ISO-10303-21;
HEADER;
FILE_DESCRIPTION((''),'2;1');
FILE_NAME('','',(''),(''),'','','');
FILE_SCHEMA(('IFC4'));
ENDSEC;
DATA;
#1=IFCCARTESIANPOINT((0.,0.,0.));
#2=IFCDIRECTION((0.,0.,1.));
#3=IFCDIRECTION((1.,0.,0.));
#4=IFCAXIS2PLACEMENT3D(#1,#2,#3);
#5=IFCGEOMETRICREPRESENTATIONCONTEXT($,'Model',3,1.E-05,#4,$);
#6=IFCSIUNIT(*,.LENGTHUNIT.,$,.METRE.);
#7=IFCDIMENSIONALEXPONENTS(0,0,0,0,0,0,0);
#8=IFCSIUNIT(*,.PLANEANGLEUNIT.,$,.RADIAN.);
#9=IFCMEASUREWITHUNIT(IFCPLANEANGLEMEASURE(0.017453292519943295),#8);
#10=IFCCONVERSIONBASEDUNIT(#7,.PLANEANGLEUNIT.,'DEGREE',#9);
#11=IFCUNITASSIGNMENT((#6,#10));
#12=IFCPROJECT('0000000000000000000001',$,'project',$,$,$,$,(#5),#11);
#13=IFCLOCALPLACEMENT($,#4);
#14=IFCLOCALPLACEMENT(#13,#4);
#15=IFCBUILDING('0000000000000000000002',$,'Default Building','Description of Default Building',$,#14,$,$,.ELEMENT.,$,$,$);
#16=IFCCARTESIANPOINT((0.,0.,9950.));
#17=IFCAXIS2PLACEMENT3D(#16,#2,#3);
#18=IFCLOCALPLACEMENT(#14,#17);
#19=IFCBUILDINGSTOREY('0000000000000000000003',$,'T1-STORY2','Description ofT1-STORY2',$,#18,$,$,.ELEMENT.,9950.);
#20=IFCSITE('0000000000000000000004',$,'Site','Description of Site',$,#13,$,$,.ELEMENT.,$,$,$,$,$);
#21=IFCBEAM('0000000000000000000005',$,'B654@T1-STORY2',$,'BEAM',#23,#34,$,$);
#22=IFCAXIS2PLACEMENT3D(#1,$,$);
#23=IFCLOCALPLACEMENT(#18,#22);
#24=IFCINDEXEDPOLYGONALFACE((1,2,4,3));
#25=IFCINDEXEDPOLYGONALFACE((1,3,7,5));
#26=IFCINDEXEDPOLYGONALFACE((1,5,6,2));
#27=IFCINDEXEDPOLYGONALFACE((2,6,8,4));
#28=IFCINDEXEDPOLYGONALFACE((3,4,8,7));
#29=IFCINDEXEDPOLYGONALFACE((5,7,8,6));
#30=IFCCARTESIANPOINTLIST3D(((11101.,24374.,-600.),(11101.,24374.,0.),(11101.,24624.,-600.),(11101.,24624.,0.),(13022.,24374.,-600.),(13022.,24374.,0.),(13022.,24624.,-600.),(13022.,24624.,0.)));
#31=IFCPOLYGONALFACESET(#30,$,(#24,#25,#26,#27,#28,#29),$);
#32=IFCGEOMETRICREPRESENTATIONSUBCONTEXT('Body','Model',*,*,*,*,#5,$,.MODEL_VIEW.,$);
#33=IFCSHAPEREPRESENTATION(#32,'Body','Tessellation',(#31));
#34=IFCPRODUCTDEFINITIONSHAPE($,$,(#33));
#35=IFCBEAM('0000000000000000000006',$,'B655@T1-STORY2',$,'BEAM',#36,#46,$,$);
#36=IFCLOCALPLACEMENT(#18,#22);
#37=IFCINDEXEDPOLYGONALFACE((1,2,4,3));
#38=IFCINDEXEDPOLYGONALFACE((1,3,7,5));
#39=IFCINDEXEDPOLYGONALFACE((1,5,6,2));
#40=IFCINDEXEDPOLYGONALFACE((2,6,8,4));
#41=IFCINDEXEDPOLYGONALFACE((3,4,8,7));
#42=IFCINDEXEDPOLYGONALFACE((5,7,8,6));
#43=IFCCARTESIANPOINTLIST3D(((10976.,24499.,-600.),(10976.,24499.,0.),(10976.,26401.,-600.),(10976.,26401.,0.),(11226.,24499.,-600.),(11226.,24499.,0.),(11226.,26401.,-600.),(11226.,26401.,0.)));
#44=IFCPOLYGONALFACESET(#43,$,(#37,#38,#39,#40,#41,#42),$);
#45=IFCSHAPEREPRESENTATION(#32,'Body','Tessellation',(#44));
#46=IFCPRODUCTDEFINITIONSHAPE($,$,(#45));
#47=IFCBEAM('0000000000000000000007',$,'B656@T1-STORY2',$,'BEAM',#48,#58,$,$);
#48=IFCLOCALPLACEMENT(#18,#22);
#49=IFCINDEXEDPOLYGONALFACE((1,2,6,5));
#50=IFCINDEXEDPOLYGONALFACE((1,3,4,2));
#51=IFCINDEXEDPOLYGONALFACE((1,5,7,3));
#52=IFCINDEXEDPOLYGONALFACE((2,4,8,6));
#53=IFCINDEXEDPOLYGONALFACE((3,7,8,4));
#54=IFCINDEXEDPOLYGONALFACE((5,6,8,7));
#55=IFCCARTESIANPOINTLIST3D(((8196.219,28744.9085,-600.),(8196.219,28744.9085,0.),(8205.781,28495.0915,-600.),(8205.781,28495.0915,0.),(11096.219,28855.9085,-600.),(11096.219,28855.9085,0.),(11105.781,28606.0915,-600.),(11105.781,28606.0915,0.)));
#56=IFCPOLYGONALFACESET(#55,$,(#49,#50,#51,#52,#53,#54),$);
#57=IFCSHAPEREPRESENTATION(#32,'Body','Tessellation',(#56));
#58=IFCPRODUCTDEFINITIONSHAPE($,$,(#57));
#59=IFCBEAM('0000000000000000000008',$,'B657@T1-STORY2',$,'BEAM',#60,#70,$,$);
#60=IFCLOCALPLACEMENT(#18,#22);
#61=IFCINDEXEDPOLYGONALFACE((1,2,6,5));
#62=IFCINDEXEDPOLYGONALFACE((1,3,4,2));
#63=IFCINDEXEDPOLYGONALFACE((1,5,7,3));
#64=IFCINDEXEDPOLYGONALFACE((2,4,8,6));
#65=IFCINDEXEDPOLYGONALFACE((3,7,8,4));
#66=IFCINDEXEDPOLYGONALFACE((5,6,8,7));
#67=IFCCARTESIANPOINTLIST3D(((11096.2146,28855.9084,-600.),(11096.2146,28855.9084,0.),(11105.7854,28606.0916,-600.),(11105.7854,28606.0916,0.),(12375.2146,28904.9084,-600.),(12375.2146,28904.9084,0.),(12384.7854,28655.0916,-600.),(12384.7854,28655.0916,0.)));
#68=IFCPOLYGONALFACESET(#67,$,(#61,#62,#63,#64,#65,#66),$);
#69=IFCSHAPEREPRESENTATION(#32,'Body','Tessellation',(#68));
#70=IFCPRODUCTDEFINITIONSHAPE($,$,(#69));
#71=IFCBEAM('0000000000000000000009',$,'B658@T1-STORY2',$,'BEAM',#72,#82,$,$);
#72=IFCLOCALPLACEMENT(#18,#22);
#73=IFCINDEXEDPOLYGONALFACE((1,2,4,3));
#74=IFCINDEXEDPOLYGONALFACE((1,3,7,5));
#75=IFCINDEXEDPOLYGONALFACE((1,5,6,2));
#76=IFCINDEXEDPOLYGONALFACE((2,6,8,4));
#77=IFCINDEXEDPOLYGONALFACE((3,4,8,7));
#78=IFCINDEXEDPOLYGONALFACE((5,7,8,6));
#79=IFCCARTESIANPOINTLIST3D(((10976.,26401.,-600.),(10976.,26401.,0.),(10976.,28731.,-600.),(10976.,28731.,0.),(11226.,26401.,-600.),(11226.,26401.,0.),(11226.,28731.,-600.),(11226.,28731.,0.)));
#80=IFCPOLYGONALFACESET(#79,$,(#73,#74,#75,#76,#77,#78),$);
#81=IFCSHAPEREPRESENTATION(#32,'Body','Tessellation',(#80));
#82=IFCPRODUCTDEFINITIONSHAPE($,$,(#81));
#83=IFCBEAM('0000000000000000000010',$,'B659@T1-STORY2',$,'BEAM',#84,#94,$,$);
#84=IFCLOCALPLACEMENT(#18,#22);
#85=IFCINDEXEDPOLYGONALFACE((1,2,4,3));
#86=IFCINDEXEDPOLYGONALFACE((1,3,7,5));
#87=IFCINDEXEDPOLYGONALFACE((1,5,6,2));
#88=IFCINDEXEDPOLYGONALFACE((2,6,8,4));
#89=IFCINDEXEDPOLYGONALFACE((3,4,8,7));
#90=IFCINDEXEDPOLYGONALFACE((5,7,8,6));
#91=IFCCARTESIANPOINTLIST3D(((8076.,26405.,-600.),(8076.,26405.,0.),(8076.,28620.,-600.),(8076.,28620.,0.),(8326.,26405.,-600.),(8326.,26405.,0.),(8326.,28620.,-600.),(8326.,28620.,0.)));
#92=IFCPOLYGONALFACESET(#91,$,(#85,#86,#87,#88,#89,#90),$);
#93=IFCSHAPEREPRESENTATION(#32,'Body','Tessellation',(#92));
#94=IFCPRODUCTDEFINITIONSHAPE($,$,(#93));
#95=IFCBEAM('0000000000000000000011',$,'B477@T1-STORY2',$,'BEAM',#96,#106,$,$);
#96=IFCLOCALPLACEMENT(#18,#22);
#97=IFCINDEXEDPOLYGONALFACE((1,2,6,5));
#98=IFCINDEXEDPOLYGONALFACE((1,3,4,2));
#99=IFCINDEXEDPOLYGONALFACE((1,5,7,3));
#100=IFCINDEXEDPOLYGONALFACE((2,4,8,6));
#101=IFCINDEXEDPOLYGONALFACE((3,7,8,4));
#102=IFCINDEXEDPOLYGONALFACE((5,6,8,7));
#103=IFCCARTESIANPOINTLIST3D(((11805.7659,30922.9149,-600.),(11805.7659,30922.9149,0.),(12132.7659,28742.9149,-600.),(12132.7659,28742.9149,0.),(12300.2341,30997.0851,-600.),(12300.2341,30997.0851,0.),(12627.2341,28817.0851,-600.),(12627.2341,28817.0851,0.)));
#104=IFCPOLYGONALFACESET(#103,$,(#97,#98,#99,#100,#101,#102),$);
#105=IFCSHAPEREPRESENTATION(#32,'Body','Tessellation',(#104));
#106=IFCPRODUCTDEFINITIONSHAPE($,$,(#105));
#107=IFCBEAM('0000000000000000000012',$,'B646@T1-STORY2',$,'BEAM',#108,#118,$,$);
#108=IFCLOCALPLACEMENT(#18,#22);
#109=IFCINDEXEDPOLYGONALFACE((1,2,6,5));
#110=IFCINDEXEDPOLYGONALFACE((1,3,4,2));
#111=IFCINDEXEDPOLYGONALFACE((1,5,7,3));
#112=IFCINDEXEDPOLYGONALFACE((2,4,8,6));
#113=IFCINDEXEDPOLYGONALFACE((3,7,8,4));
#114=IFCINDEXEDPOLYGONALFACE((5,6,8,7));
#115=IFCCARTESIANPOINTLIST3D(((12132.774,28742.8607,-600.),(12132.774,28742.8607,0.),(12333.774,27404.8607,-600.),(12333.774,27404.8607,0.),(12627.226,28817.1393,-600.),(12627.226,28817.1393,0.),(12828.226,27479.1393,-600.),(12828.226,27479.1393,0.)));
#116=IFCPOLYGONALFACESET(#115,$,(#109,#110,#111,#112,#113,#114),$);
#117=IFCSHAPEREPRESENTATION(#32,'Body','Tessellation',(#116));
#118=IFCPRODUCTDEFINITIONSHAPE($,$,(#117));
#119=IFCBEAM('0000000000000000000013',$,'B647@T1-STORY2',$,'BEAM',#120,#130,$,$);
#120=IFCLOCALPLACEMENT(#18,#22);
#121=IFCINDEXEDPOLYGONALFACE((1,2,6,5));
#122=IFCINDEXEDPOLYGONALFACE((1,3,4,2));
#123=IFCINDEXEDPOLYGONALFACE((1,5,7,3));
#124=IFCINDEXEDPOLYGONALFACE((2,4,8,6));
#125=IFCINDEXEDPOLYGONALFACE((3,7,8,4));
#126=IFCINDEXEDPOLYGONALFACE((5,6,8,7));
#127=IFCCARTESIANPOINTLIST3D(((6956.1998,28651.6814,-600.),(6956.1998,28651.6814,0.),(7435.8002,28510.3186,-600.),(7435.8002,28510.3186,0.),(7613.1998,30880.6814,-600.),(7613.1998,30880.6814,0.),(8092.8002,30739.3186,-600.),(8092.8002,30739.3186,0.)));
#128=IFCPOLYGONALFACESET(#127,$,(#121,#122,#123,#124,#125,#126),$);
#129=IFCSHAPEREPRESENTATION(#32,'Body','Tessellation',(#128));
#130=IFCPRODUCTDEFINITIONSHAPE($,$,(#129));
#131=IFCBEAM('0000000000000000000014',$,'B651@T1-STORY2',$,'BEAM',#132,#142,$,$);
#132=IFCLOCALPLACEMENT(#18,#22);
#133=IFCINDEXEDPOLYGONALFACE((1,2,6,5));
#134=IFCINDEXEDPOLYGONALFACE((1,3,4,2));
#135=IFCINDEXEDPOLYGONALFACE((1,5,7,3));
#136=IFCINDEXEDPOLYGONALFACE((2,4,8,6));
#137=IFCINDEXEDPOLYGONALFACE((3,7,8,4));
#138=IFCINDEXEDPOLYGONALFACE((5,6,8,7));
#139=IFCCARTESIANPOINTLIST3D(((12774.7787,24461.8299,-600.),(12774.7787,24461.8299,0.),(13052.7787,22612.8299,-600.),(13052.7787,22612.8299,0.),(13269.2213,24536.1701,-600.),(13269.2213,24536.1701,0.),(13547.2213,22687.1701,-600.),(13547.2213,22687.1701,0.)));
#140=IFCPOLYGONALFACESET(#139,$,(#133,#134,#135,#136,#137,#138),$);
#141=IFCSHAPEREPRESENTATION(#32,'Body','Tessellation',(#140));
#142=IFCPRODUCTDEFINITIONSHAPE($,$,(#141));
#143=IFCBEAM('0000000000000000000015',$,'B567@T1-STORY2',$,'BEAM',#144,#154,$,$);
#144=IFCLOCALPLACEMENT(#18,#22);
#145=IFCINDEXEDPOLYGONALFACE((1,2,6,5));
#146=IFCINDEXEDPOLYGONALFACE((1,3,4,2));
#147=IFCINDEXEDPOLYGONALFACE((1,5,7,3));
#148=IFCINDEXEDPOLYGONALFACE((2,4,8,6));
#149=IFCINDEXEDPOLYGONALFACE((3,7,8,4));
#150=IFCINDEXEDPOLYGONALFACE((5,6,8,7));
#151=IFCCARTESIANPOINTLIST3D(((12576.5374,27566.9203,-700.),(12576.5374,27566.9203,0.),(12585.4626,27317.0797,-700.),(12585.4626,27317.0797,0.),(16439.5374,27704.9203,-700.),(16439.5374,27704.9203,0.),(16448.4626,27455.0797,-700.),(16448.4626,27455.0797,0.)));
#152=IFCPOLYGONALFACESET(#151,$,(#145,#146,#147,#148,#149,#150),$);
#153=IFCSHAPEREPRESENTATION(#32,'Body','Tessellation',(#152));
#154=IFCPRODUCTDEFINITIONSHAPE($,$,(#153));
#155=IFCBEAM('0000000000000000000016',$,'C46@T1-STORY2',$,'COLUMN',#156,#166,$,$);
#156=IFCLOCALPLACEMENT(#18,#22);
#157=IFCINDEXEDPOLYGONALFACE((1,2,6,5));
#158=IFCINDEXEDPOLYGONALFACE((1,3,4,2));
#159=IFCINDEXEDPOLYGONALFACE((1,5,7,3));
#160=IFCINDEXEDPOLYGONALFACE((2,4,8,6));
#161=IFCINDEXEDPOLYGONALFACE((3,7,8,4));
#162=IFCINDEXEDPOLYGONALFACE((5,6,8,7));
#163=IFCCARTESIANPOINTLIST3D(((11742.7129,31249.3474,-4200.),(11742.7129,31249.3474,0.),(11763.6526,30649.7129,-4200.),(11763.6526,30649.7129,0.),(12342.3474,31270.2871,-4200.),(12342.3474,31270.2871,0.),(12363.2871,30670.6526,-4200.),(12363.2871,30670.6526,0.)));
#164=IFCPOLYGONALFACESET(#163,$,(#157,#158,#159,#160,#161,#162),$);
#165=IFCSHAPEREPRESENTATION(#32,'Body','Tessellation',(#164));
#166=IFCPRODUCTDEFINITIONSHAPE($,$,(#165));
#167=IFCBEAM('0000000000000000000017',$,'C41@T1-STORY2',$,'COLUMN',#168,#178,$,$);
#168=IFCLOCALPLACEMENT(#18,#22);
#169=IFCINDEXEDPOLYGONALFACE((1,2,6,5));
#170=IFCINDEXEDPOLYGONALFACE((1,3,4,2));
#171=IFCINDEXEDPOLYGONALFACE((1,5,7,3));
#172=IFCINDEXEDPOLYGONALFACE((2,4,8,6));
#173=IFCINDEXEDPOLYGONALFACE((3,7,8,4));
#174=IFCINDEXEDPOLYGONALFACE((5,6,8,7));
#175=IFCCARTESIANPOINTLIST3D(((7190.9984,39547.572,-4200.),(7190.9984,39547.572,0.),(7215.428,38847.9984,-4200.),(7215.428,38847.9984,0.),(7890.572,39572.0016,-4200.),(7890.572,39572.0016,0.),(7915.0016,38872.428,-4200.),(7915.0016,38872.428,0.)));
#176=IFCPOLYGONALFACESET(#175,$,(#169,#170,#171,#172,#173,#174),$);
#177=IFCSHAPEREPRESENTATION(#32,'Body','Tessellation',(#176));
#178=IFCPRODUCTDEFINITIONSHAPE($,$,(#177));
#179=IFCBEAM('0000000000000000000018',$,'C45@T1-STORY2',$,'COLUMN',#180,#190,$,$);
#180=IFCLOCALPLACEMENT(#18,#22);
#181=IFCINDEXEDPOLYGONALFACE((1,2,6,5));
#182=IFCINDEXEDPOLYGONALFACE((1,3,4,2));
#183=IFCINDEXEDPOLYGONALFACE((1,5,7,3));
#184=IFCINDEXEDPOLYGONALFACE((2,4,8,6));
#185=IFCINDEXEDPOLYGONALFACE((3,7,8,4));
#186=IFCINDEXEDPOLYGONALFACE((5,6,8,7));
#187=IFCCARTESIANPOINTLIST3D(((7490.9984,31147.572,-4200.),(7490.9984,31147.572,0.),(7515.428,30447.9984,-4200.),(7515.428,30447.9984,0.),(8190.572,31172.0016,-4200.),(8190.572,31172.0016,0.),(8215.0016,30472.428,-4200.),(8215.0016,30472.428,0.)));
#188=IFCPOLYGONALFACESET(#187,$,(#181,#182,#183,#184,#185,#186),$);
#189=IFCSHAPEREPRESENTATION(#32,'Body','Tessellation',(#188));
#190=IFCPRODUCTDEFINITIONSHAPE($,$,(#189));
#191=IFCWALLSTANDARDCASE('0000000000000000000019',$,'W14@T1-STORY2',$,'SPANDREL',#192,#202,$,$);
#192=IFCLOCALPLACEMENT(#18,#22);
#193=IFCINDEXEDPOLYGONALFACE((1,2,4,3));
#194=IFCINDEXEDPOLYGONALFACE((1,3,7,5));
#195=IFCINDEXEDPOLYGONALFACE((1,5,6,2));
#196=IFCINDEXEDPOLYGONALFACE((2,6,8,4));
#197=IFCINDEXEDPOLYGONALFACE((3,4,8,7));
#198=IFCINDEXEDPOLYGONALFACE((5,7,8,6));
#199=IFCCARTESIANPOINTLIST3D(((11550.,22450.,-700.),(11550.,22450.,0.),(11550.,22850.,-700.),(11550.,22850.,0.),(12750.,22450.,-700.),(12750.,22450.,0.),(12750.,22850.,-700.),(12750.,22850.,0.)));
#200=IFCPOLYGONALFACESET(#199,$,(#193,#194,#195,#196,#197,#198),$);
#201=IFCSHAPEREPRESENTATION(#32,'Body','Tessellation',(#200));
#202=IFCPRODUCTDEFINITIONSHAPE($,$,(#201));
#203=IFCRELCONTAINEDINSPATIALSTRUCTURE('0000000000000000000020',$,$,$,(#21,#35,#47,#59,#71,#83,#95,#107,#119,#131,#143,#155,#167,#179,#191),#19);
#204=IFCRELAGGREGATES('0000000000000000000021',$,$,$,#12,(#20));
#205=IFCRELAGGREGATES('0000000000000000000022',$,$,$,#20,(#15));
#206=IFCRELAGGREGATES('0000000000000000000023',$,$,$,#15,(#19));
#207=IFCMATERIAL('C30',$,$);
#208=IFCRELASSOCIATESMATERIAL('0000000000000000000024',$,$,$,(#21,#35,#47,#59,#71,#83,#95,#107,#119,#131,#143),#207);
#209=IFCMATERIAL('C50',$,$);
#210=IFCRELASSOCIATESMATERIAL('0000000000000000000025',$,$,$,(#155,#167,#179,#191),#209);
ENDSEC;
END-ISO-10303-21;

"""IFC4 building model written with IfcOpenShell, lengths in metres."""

from ifc_helpers import new_model, entity, si_unit, converted_unit, frame, origin_with_axes, place, context, subcontext, project, spatial, indexed_curve, rectangle, outline, extrude, material, element, save


model = new_model("IFC4")

# Units and contexts
model_context = context("Model", 3, precision=1e-05, world=origin_with_axes())
body_context = subcontext(model_context, "Body", "Model", "MODEL_VIEW")
ifc_project = project(units=[si_unit("LENGTHUNIT", "METRE"), converted_unit("PLANEANGLEUNIT", "DEGREE", entity("IfcPlaneAngleMeasure", 0.017453292519943295), si_unit("PLANEANGLEUNIT", "RADIAN"), dimensions=[0, 0, 0, 0, 0, 0, 0])], contexts=[model_context])

# Site, building, storey
site_placement = place(None, origin_with_axes())
site = spatial("IfcSite", under=ifc_project, at=site_placement, Name="Site", Description="Description of Site", CompositionType="ELEMENT")
building_placement = place(site_placement, origin_with_axes())
building = spatial("IfcBuilding", under=site, at=building_placement, Name="Default Building", Description="Description of Default Building", CompositionType="ELEMENT")
storey_placement = place(building_placement, frame((0.0, 0.0, 9950.0), z_axis=(0.0, 0.0, 1.0), x_axis=(1.0, 0.0, 0.0)))
storey = spatial("IfcBuildingStorey", under=building, at=storey_placement, Name="T1-STORY2", Description="Description ofT1-STORY2", CompositionType="ELEMENT", Elevation=9950.0)

# Beams
ifc_material_1 = material(Name="C30")
beam_1_placement = place(storey_placement, frame((11101.0, 24499.0, -300.0), z_axis=(1.0, 0.0, 0.0), x_axis=(0.0, 1.0, 0.0)))
element("IfcBeam", 1, at=beam_1_placement, inside=storey, material=ifc_material_1, Name="B654@T1-STORY2", ObjectType="BEAM", context=body_context, shape_type="SweptSolid", body=[
    extrude(rectangle(XDim=250.0, YDim=600.0), origin_with_axes(), (0.0, 0.0, 1.0), 1921.0),
])
beam_2_placement = place(storey_placement, frame((11101.0, 24499.0, -300.0), z_axis=(0.0, 1.0, 0.0), x_axis=(-1.0, 0.0, 0.0)))
element("IfcBeam", 2, at=beam_2_placement, inside=storey, material=ifc_material_1, Name="B655@T1-STORY2", ObjectType="BEAM", context=body_context, shape_type="SweptSolid", body=[
    extrude(rectangle(XDim=250.0, YDim=600.0), origin_with_axes(), (0.0, 0.0, 1.0), 1902.0),
])
beam_3_placement = place(storey_placement, frame((8201.0, 28620.0, -300.0), z_axis=(0.999268, 0.038248, 0.0), x_axis=(-0.038248, 0.999268, 0.0)))
element("IfcBeam", 3, at=beam_3_placement, inside=storey, material=ifc_material_1, Name="B656@T1-STORY2", ObjectType="BEAM", context=body_context, shape_type="SweptSolid", body=[
    extrude(rectangle(XDim=250.0, YDim=600.0), origin_with_axes(), (0.0, 0.0, 1.0), 2902.1235),
])
beam_4_placement = place(storey_placement, frame((11101.0, 28731.0, -300.0), z_axis=(0.999267, 0.038283, 0.0), x_axis=(-0.038283, 0.999267, 0.0)))
element("IfcBeam", 4, at=beam_4_placement, inside=storey, material=ifc_material_1, Name="B657@T1-STORY2", ObjectType="BEAM", context=body_context, shape_type="SweptSolid", body=[
    extrude(rectangle(XDim=250.0, YDim=600.0), origin_with_axes(), (0.0, 0.0, 1.0), 1279.9383),
])
beam_5_placement = place(storey_placement, frame((11101.0, 26401.0, -300.0), z_axis=(0.0, 1.0, 0.0), x_axis=(-1.0, 0.0, 0.0)))
element("IfcBeam", 5, at=beam_5_placement, inside=storey, material=ifc_material_1, Name="B658@T1-STORY2", ObjectType="BEAM", context=body_context, shape_type="SweptSolid", body=[
    extrude(rectangle(XDim=250.0, YDim=600.0), origin_with_axes(), (0.0, 0.0, 1.0), 2330.0),
])
beam_6_placement = place(storey_placement, frame((8201.0, 26405.0, -300.0), z_axis=(0.0, 1.0, 0.0), x_axis=(-1.0, 0.0, 0.0)))
element("IfcBeam", 6, at=beam_6_placement, inside=storey, material=ifc_material_1, Name="B659@T1-STORY2", ObjectType="BEAM", context=body_context, shape_type="SweptSolid", body=[
    extrude(rectangle(XDim=250.0, YDim=600.0), origin_with_axes(), (0.0, 0.0, 1.0), 2215.0),
])
beam_7_placement = place(storey_placement, frame((12053.0, 30960.0, -300.0), z_axis=(0.14834, -0.988936, 0.0), x_axis=(0.988936, 0.14834, 0.0)))
element("IfcBeam", 7, at=beam_7_placement, inside=storey, material=ifc_material_1, Name="B477@T1-STORY2", ObjectType="BEAM", context=body_context, shape_type="SweptSolid", body=[
    extrude(rectangle(XDim=500.0, YDim=600.0), origin_with_axes(), (0.0, 0.0, 1.0), 2204.3886),
])
beam_8_placement = place(storey_placement, frame((12380.0, 28780.0, -300.0), z_axis=(0.148557, -0.988904, 0.0), x_axis=(0.988904, 0.148557, 0.0)))
element("IfcBeam", 8, at=beam_8_placement, inside=storey, material=ifc_material_1, Name="B646@T1-STORY2", ObjectType="BEAM", context=body_context, shape_type="SweptSolid", body=[
    extrude(rectangle(XDim=500.0, YDim=600.0), origin_with_axes(), (0.0, 0.0, 1.0), 1353.0133),
])
beam_9_placement = place(storey_placement, frame((7196.0, 28581.0, -300.0), z_axis=(0.282725, 0.959201, 0.0), x_axis=(-0.959201, 0.282725, 0.0)))
element("IfcBeam", 9, at=beam_9_placement, inside=storey, material=ifc_material_1, Name="B647@T1-STORY2", ObjectType="BEAM", context=body_context, shape_type="SweptSolid", body=[
    extrude(rectangle(XDim=500.0, YDim=600.0), origin_with_axes(), (0.0, 0.0, 1.0), 2323.8094),
])
beam_10_placement = place(storey_placement, frame((13022.0, 24499.0, -300.0), z_axis=(0.14868, -0.988885, 0.0), x_axis=(0.988885, 0.14868, 0.0)))
element("IfcBeam", 10, at=beam_10_placement, inside=storey, material=ifc_material_1, Name="B651@T1-STORY2", ObjectType="BEAM", context=body_context, shape_type="SweptSolid", body=[
    extrude(rectangle(XDim=500.0, YDim=600.0), origin_with_axes(), (0.0, 0.0, 1.0), 1869.7821),
])
beam_11_placement = place(storey_placement, frame((12581.0, 27442.0, -350.0), z_axis=(0.999363, 0.035701, 0.0), x_axis=(-0.035701, 0.999363, 0.0)))
element("IfcBeam", 11, at=beam_11_placement, inside=storey, material=ifc_material_1, Name="B567@T1-STORY2", ObjectType="BEAM", context=body_context, shape_type="SweptSolid", body=[
    extrude(rectangle(XDim=250.0, YDim=700.0), origin_with_axes(), (0.0, 0.0, 1.0), 3865.4641),
])
ifc_material_2 = material(Name="C50")
beam_12_placement = place(storey_placement, frame((12053.0, 30960.0, -4200.0), z_axis=(0.0, 0.0, 1.0), x_axis=(-0.999391, -0.034899, 0.0)))
element("IfcBeam", 12, at=beam_12_placement, inside=storey, material=ifc_material_2, Name="C46@T1-STORY2", ObjectType="COLUMN", context=body_context, shape_type="SweptSolid", body=[
    extrude(rectangle(XDim=600.0, YDim=600.0), origin_with_axes(), (0.0, 0.0, 1.0), 4200.0),
])
for number, where, z_axis, x_axis, name in (
    (13, (7553.0, 39210.0, -4200.0), (0.0, 0.0, 1.0), (-0.999391, -0.034899, 0.0), "C41@T1-STORY2"),
    (14, (7853.0, 30810.0, -4200.0), (0.0, 0.0, 1.0), (-0.999391, -0.034899, 0.0), "C45@T1-STORY2"),
):
    element("IfcBeam", number, at=place(storey_placement, frame(where, z_axis=z_axis, x_axis=x_axis)), inside=storey, material=ifc_material_2, Name=name, ObjectType="COLUMN", context=body_context, shape_type="SweptSolid", body=[
        extrude(rectangle(XDim=700.0, YDim=700.0), origin_with_axes(), (0.0, 0.0, 1.0), 4200.0),
    ])

# Wall
wall_1_placement = place(storey_placement, frame((11550.0, 22650.0, -700.0), z_axis=(0.0, 0.0, 1.0), x_axis=(1.0, 0.0, 0.0)))
element("IfcWallStandardCase", 15, at=wall_1_placement, inside=storey, material=ifc_material_2, Name="W14@T1-STORY2", ObjectType="SPANDREL", context=body_context, shape_type="SweptSolid", body=[
    extrude(outline(indexed_curve([(0.0, -200.0), (0.0, 200.0), (1200.0, 200.0), (1200.0, -200.0), (0.0, -200.0)], self_intersect=False)), origin_with_axes(), (0.0, 0.0, 1.0), 700.0),
])

save(model, "model.ifc")
